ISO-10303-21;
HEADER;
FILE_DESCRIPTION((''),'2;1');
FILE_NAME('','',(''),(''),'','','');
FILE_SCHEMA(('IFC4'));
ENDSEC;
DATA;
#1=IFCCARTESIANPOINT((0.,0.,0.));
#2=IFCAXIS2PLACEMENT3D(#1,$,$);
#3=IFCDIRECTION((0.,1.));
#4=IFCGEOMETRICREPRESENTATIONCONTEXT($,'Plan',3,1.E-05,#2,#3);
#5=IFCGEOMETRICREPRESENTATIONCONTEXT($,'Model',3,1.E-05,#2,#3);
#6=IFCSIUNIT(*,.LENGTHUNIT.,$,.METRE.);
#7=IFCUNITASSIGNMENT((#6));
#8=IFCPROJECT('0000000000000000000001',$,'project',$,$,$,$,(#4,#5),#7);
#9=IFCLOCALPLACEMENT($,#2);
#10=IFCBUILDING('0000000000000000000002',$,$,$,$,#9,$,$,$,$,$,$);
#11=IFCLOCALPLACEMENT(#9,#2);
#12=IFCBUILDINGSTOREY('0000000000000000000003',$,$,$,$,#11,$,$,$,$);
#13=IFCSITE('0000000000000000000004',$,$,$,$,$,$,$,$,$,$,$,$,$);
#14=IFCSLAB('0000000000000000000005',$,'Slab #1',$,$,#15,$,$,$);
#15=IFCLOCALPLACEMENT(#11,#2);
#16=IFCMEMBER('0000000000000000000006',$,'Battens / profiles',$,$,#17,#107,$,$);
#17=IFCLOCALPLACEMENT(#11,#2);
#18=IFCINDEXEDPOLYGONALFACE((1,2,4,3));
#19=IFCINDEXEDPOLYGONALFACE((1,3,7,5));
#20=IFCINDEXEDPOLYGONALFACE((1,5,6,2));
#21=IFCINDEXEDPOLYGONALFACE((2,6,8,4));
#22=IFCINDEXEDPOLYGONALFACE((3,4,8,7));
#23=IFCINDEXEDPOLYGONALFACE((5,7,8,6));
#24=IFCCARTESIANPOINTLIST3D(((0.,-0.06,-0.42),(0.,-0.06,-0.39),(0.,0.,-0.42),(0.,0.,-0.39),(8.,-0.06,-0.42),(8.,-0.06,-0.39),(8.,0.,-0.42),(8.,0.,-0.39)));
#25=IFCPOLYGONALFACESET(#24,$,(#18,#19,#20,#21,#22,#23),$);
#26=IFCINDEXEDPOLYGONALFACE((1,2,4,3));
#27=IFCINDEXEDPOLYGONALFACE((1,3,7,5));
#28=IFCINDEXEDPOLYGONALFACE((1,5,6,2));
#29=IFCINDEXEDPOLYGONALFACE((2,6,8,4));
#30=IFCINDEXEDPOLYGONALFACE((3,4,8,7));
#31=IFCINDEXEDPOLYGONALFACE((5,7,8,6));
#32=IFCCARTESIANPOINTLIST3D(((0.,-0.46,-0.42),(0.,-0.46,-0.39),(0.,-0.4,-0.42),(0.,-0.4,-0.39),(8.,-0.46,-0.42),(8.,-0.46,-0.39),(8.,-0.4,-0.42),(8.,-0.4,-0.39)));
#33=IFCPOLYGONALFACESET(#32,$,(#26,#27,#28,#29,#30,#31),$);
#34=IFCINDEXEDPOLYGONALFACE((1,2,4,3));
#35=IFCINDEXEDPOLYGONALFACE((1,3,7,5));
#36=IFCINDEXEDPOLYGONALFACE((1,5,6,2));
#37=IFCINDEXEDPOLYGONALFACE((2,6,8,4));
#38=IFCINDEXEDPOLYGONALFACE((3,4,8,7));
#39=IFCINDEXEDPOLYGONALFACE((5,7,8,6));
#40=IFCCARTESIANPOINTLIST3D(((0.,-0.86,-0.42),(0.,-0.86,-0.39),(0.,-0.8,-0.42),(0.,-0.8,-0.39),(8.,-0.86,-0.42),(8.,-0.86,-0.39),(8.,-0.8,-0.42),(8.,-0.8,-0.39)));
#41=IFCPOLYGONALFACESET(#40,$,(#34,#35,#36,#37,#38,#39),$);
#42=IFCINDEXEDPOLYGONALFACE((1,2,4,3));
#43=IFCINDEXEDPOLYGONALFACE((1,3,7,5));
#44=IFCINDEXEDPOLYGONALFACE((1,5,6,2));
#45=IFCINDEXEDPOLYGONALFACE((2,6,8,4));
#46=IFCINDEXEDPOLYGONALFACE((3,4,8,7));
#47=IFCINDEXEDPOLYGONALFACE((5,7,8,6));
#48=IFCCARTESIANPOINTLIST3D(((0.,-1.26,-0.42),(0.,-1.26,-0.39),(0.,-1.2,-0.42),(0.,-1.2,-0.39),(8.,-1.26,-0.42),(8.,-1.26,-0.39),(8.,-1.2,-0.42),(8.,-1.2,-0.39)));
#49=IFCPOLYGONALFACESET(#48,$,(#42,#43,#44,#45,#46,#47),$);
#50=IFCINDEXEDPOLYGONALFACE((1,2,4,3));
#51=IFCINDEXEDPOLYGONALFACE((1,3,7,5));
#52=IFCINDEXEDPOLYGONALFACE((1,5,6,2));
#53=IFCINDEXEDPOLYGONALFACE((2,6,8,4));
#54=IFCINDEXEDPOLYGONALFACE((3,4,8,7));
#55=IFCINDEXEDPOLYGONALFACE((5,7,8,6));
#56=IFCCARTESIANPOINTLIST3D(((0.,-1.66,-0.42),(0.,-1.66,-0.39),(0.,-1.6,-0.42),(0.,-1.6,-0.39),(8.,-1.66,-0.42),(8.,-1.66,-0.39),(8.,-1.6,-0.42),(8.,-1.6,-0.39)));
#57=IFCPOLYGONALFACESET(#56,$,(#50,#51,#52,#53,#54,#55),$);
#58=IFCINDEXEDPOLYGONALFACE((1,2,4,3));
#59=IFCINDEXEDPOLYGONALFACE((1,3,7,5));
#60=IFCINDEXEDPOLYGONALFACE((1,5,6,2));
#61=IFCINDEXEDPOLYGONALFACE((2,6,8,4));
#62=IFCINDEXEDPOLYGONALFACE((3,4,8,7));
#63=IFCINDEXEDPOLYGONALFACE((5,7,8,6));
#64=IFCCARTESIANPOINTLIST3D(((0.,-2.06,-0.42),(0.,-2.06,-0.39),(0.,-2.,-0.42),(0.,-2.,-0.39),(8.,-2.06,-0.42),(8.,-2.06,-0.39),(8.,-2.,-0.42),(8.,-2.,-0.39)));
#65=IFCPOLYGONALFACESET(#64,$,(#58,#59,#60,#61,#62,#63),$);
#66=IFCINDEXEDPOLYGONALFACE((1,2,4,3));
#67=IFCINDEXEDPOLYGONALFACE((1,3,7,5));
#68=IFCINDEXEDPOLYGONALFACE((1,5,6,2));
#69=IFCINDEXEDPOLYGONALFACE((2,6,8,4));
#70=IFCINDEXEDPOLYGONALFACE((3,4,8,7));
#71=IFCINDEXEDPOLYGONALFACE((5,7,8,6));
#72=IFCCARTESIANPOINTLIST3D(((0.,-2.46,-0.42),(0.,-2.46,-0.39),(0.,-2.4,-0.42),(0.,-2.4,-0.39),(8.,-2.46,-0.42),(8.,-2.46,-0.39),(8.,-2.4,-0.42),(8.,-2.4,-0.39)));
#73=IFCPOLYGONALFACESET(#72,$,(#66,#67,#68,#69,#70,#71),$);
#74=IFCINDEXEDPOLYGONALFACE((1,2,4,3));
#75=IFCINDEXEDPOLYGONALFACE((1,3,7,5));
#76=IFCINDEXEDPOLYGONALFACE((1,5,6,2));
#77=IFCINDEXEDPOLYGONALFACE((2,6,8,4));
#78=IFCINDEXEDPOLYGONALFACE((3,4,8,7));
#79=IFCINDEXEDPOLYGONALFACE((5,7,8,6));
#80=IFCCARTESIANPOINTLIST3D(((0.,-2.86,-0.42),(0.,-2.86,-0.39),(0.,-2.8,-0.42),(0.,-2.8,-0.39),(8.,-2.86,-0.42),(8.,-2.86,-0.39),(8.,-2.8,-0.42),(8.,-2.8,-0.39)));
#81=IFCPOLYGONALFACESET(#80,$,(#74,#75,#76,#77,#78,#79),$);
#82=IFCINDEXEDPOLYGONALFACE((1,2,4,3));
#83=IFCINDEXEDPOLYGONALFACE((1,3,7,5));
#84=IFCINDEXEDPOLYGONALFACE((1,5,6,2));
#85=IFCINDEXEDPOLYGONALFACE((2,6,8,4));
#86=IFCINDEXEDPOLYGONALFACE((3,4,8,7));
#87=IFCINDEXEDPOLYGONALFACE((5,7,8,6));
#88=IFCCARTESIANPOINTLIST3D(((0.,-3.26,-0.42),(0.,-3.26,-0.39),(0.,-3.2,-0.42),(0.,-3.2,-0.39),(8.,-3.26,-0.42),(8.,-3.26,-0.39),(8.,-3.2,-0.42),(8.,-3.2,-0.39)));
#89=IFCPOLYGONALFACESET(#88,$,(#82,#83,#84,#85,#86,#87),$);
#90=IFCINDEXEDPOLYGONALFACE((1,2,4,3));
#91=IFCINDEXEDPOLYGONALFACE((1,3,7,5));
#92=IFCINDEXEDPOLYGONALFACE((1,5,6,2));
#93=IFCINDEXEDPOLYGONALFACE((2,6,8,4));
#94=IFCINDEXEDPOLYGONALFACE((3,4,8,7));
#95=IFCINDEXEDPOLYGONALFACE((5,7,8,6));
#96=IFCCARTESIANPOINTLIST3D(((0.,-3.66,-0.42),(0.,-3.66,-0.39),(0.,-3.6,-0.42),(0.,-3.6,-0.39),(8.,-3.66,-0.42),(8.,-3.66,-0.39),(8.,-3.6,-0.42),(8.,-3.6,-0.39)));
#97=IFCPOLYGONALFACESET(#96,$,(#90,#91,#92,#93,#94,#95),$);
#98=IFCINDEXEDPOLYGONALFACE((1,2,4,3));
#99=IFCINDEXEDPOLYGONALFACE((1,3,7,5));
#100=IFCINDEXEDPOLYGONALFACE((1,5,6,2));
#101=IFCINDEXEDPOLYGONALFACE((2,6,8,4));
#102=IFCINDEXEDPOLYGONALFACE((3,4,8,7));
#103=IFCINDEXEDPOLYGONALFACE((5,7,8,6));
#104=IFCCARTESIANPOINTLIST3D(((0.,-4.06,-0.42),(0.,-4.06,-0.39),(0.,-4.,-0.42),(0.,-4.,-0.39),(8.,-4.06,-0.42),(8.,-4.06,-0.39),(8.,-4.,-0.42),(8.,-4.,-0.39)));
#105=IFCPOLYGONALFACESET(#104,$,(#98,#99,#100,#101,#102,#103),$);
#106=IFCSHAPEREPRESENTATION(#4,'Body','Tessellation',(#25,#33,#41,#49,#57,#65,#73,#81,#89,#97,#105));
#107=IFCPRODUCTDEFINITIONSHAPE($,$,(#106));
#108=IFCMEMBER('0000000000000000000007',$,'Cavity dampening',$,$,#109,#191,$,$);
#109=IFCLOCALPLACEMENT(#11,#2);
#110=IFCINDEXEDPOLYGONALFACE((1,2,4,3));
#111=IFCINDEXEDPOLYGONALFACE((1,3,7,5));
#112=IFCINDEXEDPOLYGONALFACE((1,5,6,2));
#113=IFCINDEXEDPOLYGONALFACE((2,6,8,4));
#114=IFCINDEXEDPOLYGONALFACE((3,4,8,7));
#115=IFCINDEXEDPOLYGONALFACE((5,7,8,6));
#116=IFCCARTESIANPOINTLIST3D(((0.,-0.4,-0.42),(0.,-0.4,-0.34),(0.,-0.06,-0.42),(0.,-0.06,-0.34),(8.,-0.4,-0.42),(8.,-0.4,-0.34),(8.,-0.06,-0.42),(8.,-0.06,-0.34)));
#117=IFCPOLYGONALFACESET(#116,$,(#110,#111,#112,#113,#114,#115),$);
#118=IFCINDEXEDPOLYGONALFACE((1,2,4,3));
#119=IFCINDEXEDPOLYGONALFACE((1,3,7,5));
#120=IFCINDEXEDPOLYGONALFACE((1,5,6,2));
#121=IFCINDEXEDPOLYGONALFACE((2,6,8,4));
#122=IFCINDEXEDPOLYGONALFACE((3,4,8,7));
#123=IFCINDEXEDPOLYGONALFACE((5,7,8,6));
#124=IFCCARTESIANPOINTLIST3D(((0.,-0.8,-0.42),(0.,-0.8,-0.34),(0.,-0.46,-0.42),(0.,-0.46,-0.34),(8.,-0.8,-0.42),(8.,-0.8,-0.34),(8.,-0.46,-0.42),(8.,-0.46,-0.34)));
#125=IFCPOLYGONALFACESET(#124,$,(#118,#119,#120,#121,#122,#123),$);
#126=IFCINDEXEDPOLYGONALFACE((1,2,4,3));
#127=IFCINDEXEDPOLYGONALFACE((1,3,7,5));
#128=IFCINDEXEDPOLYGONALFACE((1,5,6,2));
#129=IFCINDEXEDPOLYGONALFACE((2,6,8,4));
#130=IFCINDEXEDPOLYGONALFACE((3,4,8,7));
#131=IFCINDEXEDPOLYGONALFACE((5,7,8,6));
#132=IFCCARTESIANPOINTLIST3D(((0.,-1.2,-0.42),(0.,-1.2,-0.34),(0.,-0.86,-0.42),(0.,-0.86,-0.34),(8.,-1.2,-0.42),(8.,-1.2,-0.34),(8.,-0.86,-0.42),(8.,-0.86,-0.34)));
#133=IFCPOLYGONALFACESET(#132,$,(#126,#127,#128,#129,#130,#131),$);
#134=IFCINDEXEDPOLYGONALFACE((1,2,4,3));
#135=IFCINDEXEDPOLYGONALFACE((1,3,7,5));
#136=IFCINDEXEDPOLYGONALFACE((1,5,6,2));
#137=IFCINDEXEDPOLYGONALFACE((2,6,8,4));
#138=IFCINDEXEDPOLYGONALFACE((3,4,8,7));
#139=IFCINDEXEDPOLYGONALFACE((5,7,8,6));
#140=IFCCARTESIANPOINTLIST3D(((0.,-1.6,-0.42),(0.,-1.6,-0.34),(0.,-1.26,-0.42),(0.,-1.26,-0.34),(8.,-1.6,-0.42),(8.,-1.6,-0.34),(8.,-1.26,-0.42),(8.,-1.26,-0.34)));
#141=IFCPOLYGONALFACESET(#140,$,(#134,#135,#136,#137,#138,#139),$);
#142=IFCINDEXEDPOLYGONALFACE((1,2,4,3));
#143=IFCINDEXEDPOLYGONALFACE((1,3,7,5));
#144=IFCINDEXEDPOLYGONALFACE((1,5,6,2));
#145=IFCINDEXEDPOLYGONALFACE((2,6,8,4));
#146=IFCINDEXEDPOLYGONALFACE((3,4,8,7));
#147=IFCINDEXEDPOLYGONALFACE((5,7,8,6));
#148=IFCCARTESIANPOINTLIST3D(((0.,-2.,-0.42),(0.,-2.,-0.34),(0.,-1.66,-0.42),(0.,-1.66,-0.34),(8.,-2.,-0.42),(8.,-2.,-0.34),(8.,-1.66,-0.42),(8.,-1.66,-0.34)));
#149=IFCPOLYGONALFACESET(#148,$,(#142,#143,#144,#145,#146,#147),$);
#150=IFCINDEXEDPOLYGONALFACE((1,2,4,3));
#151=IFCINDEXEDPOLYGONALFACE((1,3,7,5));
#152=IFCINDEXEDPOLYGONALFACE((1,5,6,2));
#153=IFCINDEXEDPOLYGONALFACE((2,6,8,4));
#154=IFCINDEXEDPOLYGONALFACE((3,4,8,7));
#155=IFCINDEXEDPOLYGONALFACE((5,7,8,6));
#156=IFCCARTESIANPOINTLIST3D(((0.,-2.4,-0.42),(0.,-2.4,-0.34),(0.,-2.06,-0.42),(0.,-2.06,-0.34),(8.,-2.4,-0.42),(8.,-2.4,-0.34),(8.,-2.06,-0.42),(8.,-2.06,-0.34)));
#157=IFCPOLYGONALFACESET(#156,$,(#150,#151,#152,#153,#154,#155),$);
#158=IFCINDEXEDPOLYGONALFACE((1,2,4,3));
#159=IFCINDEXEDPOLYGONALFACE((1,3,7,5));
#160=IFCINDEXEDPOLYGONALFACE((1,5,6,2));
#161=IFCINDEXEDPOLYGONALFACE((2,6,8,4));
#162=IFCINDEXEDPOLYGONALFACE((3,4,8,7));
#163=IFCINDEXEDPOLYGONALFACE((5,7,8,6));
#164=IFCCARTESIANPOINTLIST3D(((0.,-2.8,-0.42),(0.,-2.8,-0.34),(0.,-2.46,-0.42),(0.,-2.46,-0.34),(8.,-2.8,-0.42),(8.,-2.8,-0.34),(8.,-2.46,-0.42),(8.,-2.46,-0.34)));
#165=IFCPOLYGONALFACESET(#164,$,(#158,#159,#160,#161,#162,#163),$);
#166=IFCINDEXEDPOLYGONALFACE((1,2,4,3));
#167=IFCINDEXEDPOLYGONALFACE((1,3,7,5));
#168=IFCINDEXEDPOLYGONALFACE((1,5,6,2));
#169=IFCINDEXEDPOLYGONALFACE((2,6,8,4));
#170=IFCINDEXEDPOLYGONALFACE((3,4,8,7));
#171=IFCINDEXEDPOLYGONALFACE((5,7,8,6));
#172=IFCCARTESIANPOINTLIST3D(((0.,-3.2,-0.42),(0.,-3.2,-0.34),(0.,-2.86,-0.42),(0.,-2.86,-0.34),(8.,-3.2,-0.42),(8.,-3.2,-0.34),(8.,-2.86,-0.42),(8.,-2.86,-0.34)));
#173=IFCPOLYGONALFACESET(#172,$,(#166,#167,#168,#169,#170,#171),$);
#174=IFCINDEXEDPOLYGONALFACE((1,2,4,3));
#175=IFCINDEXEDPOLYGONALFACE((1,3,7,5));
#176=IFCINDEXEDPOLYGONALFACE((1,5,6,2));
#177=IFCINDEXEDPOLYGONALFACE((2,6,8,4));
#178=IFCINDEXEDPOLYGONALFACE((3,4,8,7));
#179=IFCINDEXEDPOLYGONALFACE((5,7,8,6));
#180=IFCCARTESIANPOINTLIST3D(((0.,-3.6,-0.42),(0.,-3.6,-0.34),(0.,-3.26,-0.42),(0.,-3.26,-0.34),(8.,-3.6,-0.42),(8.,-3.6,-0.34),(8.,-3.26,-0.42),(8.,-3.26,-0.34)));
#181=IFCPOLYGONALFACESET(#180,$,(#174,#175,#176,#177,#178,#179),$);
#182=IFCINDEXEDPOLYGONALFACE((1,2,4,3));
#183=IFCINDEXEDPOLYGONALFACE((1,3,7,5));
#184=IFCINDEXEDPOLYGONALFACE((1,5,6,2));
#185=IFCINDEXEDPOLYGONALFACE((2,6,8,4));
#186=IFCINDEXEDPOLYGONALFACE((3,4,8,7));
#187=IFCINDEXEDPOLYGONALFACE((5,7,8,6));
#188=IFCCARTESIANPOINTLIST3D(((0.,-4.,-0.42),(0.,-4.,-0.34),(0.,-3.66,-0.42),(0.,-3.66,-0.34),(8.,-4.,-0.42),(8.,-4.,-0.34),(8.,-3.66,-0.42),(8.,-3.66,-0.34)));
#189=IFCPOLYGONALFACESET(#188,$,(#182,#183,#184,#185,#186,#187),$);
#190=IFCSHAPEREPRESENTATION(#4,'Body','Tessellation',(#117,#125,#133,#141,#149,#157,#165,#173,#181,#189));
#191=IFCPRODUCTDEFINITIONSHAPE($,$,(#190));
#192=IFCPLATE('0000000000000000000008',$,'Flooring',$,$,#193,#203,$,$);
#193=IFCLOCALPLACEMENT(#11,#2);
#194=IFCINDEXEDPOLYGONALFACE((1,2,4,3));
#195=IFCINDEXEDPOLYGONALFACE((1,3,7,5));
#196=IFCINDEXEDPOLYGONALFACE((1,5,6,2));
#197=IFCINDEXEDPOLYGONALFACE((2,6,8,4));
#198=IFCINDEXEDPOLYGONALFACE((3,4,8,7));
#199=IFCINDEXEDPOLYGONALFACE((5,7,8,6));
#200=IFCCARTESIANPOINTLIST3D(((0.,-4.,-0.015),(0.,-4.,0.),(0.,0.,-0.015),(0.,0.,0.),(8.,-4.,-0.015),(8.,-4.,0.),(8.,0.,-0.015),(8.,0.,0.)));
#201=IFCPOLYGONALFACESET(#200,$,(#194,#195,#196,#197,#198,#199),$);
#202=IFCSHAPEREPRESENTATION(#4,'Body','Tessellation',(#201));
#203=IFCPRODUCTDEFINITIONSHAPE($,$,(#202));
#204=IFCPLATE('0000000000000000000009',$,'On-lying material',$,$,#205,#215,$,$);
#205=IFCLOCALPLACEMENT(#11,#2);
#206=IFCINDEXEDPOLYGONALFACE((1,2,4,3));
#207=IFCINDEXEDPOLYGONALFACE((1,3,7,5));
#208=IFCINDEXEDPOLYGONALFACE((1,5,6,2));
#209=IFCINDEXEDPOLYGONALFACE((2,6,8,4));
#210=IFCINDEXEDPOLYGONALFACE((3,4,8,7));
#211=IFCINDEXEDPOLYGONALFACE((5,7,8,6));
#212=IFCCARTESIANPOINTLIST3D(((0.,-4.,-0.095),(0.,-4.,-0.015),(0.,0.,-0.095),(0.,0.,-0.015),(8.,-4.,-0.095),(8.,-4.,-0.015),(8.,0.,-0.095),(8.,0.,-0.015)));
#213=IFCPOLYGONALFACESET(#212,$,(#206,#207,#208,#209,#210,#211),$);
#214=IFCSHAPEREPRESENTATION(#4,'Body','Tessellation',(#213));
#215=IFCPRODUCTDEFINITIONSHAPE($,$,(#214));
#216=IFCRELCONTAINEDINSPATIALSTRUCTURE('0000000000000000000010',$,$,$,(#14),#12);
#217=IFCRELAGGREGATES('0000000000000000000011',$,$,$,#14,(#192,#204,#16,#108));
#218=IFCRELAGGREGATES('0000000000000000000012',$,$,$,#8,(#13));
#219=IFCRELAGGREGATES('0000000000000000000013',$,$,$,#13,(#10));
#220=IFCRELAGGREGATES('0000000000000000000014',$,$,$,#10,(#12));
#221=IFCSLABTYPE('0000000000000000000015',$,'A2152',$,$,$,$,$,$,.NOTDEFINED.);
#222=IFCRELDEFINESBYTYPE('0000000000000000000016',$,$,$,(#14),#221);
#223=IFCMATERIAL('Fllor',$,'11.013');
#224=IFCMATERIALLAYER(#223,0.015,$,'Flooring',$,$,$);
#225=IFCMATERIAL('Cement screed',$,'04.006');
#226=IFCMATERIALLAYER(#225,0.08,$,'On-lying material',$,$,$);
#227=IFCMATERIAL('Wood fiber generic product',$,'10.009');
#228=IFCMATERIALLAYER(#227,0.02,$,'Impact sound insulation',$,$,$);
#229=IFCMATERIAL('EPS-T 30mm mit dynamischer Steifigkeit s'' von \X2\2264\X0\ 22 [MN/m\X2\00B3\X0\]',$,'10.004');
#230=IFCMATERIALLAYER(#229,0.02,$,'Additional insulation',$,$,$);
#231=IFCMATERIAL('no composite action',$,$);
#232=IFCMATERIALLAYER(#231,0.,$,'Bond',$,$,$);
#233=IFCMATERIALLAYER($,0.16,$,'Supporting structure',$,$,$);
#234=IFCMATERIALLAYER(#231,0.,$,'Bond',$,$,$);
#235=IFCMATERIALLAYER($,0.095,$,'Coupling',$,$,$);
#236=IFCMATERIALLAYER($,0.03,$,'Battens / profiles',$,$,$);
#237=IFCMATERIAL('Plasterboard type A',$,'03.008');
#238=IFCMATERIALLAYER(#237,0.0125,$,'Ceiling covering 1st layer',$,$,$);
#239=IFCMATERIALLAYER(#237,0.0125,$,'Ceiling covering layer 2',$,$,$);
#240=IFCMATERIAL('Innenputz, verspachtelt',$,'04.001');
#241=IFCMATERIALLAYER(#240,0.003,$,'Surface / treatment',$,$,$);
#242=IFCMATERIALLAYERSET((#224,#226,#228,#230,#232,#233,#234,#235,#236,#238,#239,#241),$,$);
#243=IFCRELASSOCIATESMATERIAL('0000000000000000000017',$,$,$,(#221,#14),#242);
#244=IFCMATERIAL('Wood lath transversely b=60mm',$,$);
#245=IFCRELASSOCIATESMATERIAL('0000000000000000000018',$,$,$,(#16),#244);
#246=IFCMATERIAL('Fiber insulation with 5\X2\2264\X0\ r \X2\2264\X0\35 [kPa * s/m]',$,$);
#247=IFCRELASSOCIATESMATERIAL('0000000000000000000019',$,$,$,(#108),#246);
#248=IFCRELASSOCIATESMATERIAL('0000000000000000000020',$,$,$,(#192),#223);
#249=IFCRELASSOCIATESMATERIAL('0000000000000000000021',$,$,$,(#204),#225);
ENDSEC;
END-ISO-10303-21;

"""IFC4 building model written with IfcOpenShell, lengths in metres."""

from ifc_helpers import new_model, si_unit, direction, frame, frame_2d, origin, origin_with_axes, place, context, project, spatial, rectangle, extrude, material, layer, layer_set, type_object, element, aggregate, save


model = new_model("IFC4")

# Units and contexts
plan_context = context("Plan", 3, precision=1e-05, world=origin(), true_north=direction((0.0, 1.0)))
model_context = context("Model", 3, precision=1e-05, world=origin(), true_north=direction((0.0, 1.0)))
ifc_project = project(units=[si_unit("LENGTHUNIT", "METRE")], contexts=[plan_context, model_context])

# Site, building, storey
site = spatial("IfcSite", under=ifc_project)
building_placement = place(None, origin())
building = spatial("IfcBuilding", under=site, at=building_placement)
storey_placement = place(building_placement, origin())
storey = spatial("IfcBuildingStorey", under=building, at=storey_placement)

# Slab, members, plates
ifc_material_1 = material(Name="Fllor", Category="11.013")
ifc_layer_1 = layer(ifc_material_1, 0.015, Name="Flooring")
ifc_material_2 = material(Name="Cement screed", Category="04.006")
ifc_layer_2 = layer(ifc_material_2, 0.08, Name="On-lying material")
ifc_material_3 = material(Name="Wood fiber generic product", Category="10.009")
ifc_layer_3 = layer(ifc_material_3, 0.02, Name="Impact sound insulation")
ifc_material_4 = material(Name="EPS-T 30mm mit dynamischer Steifigkeit s' von ≤ 22 [MN/m³]", Category="10.004")
ifc_layer_4 = layer(ifc_material_4, 0.02, Name="Additional insulation")
ifc_material_5 = material(Name="no composite action")
ifc_layer_5 = layer(ifc_material_5, 0.0, Name="Bond")
ifc_layer_6 = layer(None, 0.16, Name="Supporting structure")
ifc_layer_7 = layer(ifc_material_5, 0.0, Name="Bond")
ifc_layer_8 = layer(None, 0.095, Name="Coupling")
ifc_layer_9 = layer(None, 0.03, Name="Battens / profiles")
ifc_material_6 = material(Name="Plasterboard type A", Category="03.008")
ifc_layer_10 = layer(ifc_material_6, 0.0125, Name="Ceiling covering 1st layer")
ifc_layer_11 = layer(ifc_material_6, 0.0125, Name="Ceiling covering layer 2")
ifc_material_7 = material(Name="Innenputz, verspachtelt", Category="04.001")
ifc_layer_12 = layer(ifc_material_7, 0.003, Name="Surface / treatment")
ifc_layer_set = layer_set([ifc_layer_1, ifc_layer_2, ifc_layer_3, ifc_layer_4, ifc_layer_5, ifc_layer_6, ifc_layer_7, ifc_layer_8, ifc_layer_9, ifc_layer_10, ifc_layer_11, ifc_layer_12])
slab_type = type_object("IfcSlabType", Name="A2152", PredefinedType="NOTDEFINED", material=ifc_layer_set)
slab_placement = place(None, frame((0.0, 0.0, 0.0), z_axis=(0.0, 0.0, -1.0), x_axis=(1.0, 0.0, 0.0)))
slab = element("IfcSlab", 1, at=slab_placement, inside=storey, type_object=slab_type, material=ifc_layer_set, Name="Slab #1")
ifc_material_8 = material(Name="Wood lath transversely b=60mm")
member_1_placement = place(slab_placement, origin())
member_1 = element("IfcMember", 2, at=member_1_placement, material=ifc_material_8, Name="Battens / profiles", context=plan_context, shape_type="SweptSolid", body=[
    extrude(rectangle(XDim=0.06, YDim=0.03, at=frame_2d((0.03, 0.015), x_axis=(1.0, 0.0))), frame((0.0, 0.0, 0.39), z_axis=(1.0, 0.0, 0.0), x_axis=(0.0, 1.0, 0.0)), (0.0, 0.0, 1.0), 8.0),
    extrude(rectangle(XDim=0.06, YDim=0.03, at=frame_2d((0.03, 0.015), x_axis=(1.0, 0.0))), frame((0.0, 0.4, 0.39), z_axis=(1.0, 0.0, 0.0), x_axis=(0.0, 1.0, 0.0)), (0.0, 0.0, 1.0), 8.0),
    extrude(rectangle(XDim=0.06, YDim=0.03, at=frame_2d((0.03, 0.015), x_axis=(1.0, 0.0))), frame((0.0, 0.8, 0.39), z_axis=(1.0, 0.0, 0.0), x_axis=(0.0, 1.0, 0.0)), (0.0, 0.0, 1.0), 8.0),
    extrude(rectangle(XDim=0.06, YDim=0.03, at=frame_2d((0.03, 0.015), x_axis=(1.0, 0.0))), frame((0.0, 1.2, 0.39), z_axis=(1.0, 0.0, 0.0), x_axis=(0.0, 1.0, 0.0)), (0.0, 0.0, 1.0), 8.0),
    extrude(rectangle(XDim=0.06, YDim=0.03, at=frame_2d((0.03, 0.015), x_axis=(1.0, 0.0))), frame((0.0, 1.6, 0.39), z_axis=(1.0, 0.0, 0.0), x_axis=(0.0, 1.0, 0.0)), (0.0, 0.0, 1.0), 8.0),
    extrude(rectangle(XDim=0.06, YDim=0.03, at=frame_2d((0.03, 0.015), x_axis=(1.0, 0.0))), frame((0.0, 2.0, 0.39), z_axis=(1.0, 0.0, 0.0), x_axis=(0.0, 1.0, 0.0)), (0.0, 0.0, 1.0), 8.0),
    extrude(rectangle(XDim=0.06, YDim=0.03, at=frame_2d((0.03, 0.015), x_axis=(1.0, 0.0))), frame((0.0, 2.4, 0.39), z_axis=(1.0, 0.0, 0.0), x_axis=(0.0, 1.0, 0.0)), (0.0, 0.0, 1.0), 8.0),
    extrude(rectangle(XDim=0.06, YDim=0.03, at=frame_2d((0.03, 0.015), x_axis=(1.0, 0.0))), frame((0.0, 2.8, 0.39), z_axis=(1.0, 0.0, 0.0), x_axis=(0.0, 1.0, 0.0)), (0.0, 0.0, 1.0), 8.0),
    extrude(rectangle(XDim=0.06, YDim=0.03, at=frame_2d((0.03, 0.015), x_axis=(1.0, 0.0))), frame((0.0, 3.2, 0.39), z_axis=(1.0, 0.0, 0.0), x_axis=(0.0, 1.0, 0.0)), (0.0, 0.0, 1.0), 8.0),
    extrude(rectangle(XDim=0.06, YDim=0.03, at=frame_2d((0.03, 0.015), x_axis=(1.0, 0.0))), frame((0.0, 3.6, 0.39), z_axis=(1.0, 0.0, 0.0), x_axis=(0.0, 1.0, 0.0)), (0.0, 0.0, 1.0), 8.0),
    extrude(rectangle(XDim=0.06, YDim=0.03, at=frame_2d((0.03, 0.015), x_axis=(1.0, 0.0))), frame((0.0, 4.0, 0.39), z_axis=(1.0, 0.0, 0.0), x_axis=(0.0, 1.0, 0.0)), (0.0, 0.0, 1.0), 8.0),
])
ifc_material_9 = material(Name="Fiber insulation with 5≤ r ≤35 [kPa * s/m]")
member_2_placement = place(slab_placement, origin())
member_2 = element("IfcMember", 3, at=member_2_placement, material=ifc_material_9, Name="Cavity dampening", context=plan_context, shape_type="SweptSolid", body=[
    extrude(rectangle(XDim=0.34, YDim=0.08, at=frame_2d((0.17, 0.04), x_axis=(1.0, 0.0))), frame((0.0, 0.06, 0.34), z_axis=(1.0, 0.0, 0.0), x_axis=(0.0, 1.0, 0.0)), (0.0, 0.0, 1.0), 8.0),
    extrude(rectangle(XDim=0.34, YDim=0.08, at=frame_2d((0.17, 0.04), x_axis=(1.0, 0.0))), frame((0.0, 0.46, 0.34), z_axis=(1.0, 0.0, 0.0), x_axis=(0.0, 1.0, 0.0)), (0.0, 0.0, 1.0), 8.0),
    extrude(rectangle(XDim=0.34, YDim=0.08, at=frame_2d((0.17, 0.04), x_axis=(1.0, 0.0))), frame((0.0, 0.86, 0.34), z_axis=(1.0, 0.0, 0.0), x_axis=(0.0, 1.0, 0.0)), (0.0, 0.0, 1.0), 8.0),
    extrude(rectangle(XDim=0.34, YDim=0.08, at=frame_2d((0.17, 0.04), x_axis=(1.0, 0.0))), frame((0.0, 1.26, 0.34), z_axis=(1.0, 0.0, 0.0), x_axis=(0.0, 1.0, 0.0)), (0.0, 0.0, 1.0), 8.0),
    extrude(rectangle(XDim=0.34, YDim=0.08, at=frame_2d((0.17, 0.04), x_axis=(1.0, 0.0))), frame((0.0, 1.66, 0.34), z_axis=(1.0, 0.0, 0.0), x_axis=(0.0, 1.0, 0.0)), (0.0, 0.0, 1.0), 8.0),
    extrude(rectangle(XDim=0.34, YDim=0.08, at=frame_2d((0.17, 0.04), x_axis=(1.0, 0.0))), frame((0.0, 2.06, 0.34), z_axis=(1.0, 0.0, 0.0), x_axis=(0.0, 1.0, 0.0)), (0.0, 0.0, 1.0), 8.0),
    extrude(rectangle(XDim=0.34, YDim=0.08, at=frame_2d((0.17, 0.04), x_axis=(1.0, 0.0))), frame((0.0, 2.46, 0.34), z_axis=(1.0, 0.0, 0.0), x_axis=(0.0, 1.0, 0.0)), (0.0, 0.0, 1.0), 8.0),
    extrude(rectangle(XDim=0.34, YDim=0.08, at=frame_2d((0.17, 0.04), x_axis=(1.0, 0.0))), frame((0.0, 2.86, 0.34), z_axis=(1.0, 0.0, 0.0), x_axis=(0.0, 1.0, 0.0)), (0.0, 0.0, 1.0), 8.0),
    extrude(rectangle(XDim=0.34, YDim=0.08, at=frame_2d((0.17, 0.04), x_axis=(1.0, 0.0))), frame((0.0, 3.26, 0.34), z_axis=(1.0, 0.0, 0.0), x_axis=(0.0, 1.0, 0.0)), (0.0, 0.0, 1.0), 8.0),
    extrude(rectangle(XDim=0.34, YDim=0.08, at=frame_2d((0.17, 0.04), x_axis=(1.0, 0.0))), frame((0.0, 3.66, 0.34), z_axis=(1.0, 0.0, 0.0), x_axis=(0.0, 1.0, 0.0)), (0.0, 0.0, 1.0), 8.0),
])
plate_1_placement = place(slab_placement, origin())
plate_1 = element("IfcPlate", 4, at=plate_1_placement, material=ifc_material_1, Name="Flooring", context=plan_context, shape_type="SweptSolid", body=[
    extrude(rectangle(XDim=8.0, YDim=4.0, at=frame_2d((4.0, 2.0), x_axis=(1.0, 0.0))), origin_with_axes(), (0.0, 0.0, 1.0), 0.015),
])
plate_2_placement = place(slab_placement, origin())
plate_2 = element("IfcPlate", 5, at=plate_2_placement, material=ifc_material_2, Name="On-lying material", context=plan_context, shape_type="SweptSolid", body=[
    extrude(rectangle(XDim=8.0, YDim=4.0, at=frame_2d((4.0, 2.0), x_axis=(1.0, 0.0))), frame((0.0, 0.0, 0.015), z_axis=(0.0, 0.0, 1.0), x_axis=(1.0, 0.0, 0.0)), (0.0, 0.0, 1.0), 0.08),
])
aggregate(slab, [plate_1, plate_2, member_1, member_2])

save(model, "model.ifc")
